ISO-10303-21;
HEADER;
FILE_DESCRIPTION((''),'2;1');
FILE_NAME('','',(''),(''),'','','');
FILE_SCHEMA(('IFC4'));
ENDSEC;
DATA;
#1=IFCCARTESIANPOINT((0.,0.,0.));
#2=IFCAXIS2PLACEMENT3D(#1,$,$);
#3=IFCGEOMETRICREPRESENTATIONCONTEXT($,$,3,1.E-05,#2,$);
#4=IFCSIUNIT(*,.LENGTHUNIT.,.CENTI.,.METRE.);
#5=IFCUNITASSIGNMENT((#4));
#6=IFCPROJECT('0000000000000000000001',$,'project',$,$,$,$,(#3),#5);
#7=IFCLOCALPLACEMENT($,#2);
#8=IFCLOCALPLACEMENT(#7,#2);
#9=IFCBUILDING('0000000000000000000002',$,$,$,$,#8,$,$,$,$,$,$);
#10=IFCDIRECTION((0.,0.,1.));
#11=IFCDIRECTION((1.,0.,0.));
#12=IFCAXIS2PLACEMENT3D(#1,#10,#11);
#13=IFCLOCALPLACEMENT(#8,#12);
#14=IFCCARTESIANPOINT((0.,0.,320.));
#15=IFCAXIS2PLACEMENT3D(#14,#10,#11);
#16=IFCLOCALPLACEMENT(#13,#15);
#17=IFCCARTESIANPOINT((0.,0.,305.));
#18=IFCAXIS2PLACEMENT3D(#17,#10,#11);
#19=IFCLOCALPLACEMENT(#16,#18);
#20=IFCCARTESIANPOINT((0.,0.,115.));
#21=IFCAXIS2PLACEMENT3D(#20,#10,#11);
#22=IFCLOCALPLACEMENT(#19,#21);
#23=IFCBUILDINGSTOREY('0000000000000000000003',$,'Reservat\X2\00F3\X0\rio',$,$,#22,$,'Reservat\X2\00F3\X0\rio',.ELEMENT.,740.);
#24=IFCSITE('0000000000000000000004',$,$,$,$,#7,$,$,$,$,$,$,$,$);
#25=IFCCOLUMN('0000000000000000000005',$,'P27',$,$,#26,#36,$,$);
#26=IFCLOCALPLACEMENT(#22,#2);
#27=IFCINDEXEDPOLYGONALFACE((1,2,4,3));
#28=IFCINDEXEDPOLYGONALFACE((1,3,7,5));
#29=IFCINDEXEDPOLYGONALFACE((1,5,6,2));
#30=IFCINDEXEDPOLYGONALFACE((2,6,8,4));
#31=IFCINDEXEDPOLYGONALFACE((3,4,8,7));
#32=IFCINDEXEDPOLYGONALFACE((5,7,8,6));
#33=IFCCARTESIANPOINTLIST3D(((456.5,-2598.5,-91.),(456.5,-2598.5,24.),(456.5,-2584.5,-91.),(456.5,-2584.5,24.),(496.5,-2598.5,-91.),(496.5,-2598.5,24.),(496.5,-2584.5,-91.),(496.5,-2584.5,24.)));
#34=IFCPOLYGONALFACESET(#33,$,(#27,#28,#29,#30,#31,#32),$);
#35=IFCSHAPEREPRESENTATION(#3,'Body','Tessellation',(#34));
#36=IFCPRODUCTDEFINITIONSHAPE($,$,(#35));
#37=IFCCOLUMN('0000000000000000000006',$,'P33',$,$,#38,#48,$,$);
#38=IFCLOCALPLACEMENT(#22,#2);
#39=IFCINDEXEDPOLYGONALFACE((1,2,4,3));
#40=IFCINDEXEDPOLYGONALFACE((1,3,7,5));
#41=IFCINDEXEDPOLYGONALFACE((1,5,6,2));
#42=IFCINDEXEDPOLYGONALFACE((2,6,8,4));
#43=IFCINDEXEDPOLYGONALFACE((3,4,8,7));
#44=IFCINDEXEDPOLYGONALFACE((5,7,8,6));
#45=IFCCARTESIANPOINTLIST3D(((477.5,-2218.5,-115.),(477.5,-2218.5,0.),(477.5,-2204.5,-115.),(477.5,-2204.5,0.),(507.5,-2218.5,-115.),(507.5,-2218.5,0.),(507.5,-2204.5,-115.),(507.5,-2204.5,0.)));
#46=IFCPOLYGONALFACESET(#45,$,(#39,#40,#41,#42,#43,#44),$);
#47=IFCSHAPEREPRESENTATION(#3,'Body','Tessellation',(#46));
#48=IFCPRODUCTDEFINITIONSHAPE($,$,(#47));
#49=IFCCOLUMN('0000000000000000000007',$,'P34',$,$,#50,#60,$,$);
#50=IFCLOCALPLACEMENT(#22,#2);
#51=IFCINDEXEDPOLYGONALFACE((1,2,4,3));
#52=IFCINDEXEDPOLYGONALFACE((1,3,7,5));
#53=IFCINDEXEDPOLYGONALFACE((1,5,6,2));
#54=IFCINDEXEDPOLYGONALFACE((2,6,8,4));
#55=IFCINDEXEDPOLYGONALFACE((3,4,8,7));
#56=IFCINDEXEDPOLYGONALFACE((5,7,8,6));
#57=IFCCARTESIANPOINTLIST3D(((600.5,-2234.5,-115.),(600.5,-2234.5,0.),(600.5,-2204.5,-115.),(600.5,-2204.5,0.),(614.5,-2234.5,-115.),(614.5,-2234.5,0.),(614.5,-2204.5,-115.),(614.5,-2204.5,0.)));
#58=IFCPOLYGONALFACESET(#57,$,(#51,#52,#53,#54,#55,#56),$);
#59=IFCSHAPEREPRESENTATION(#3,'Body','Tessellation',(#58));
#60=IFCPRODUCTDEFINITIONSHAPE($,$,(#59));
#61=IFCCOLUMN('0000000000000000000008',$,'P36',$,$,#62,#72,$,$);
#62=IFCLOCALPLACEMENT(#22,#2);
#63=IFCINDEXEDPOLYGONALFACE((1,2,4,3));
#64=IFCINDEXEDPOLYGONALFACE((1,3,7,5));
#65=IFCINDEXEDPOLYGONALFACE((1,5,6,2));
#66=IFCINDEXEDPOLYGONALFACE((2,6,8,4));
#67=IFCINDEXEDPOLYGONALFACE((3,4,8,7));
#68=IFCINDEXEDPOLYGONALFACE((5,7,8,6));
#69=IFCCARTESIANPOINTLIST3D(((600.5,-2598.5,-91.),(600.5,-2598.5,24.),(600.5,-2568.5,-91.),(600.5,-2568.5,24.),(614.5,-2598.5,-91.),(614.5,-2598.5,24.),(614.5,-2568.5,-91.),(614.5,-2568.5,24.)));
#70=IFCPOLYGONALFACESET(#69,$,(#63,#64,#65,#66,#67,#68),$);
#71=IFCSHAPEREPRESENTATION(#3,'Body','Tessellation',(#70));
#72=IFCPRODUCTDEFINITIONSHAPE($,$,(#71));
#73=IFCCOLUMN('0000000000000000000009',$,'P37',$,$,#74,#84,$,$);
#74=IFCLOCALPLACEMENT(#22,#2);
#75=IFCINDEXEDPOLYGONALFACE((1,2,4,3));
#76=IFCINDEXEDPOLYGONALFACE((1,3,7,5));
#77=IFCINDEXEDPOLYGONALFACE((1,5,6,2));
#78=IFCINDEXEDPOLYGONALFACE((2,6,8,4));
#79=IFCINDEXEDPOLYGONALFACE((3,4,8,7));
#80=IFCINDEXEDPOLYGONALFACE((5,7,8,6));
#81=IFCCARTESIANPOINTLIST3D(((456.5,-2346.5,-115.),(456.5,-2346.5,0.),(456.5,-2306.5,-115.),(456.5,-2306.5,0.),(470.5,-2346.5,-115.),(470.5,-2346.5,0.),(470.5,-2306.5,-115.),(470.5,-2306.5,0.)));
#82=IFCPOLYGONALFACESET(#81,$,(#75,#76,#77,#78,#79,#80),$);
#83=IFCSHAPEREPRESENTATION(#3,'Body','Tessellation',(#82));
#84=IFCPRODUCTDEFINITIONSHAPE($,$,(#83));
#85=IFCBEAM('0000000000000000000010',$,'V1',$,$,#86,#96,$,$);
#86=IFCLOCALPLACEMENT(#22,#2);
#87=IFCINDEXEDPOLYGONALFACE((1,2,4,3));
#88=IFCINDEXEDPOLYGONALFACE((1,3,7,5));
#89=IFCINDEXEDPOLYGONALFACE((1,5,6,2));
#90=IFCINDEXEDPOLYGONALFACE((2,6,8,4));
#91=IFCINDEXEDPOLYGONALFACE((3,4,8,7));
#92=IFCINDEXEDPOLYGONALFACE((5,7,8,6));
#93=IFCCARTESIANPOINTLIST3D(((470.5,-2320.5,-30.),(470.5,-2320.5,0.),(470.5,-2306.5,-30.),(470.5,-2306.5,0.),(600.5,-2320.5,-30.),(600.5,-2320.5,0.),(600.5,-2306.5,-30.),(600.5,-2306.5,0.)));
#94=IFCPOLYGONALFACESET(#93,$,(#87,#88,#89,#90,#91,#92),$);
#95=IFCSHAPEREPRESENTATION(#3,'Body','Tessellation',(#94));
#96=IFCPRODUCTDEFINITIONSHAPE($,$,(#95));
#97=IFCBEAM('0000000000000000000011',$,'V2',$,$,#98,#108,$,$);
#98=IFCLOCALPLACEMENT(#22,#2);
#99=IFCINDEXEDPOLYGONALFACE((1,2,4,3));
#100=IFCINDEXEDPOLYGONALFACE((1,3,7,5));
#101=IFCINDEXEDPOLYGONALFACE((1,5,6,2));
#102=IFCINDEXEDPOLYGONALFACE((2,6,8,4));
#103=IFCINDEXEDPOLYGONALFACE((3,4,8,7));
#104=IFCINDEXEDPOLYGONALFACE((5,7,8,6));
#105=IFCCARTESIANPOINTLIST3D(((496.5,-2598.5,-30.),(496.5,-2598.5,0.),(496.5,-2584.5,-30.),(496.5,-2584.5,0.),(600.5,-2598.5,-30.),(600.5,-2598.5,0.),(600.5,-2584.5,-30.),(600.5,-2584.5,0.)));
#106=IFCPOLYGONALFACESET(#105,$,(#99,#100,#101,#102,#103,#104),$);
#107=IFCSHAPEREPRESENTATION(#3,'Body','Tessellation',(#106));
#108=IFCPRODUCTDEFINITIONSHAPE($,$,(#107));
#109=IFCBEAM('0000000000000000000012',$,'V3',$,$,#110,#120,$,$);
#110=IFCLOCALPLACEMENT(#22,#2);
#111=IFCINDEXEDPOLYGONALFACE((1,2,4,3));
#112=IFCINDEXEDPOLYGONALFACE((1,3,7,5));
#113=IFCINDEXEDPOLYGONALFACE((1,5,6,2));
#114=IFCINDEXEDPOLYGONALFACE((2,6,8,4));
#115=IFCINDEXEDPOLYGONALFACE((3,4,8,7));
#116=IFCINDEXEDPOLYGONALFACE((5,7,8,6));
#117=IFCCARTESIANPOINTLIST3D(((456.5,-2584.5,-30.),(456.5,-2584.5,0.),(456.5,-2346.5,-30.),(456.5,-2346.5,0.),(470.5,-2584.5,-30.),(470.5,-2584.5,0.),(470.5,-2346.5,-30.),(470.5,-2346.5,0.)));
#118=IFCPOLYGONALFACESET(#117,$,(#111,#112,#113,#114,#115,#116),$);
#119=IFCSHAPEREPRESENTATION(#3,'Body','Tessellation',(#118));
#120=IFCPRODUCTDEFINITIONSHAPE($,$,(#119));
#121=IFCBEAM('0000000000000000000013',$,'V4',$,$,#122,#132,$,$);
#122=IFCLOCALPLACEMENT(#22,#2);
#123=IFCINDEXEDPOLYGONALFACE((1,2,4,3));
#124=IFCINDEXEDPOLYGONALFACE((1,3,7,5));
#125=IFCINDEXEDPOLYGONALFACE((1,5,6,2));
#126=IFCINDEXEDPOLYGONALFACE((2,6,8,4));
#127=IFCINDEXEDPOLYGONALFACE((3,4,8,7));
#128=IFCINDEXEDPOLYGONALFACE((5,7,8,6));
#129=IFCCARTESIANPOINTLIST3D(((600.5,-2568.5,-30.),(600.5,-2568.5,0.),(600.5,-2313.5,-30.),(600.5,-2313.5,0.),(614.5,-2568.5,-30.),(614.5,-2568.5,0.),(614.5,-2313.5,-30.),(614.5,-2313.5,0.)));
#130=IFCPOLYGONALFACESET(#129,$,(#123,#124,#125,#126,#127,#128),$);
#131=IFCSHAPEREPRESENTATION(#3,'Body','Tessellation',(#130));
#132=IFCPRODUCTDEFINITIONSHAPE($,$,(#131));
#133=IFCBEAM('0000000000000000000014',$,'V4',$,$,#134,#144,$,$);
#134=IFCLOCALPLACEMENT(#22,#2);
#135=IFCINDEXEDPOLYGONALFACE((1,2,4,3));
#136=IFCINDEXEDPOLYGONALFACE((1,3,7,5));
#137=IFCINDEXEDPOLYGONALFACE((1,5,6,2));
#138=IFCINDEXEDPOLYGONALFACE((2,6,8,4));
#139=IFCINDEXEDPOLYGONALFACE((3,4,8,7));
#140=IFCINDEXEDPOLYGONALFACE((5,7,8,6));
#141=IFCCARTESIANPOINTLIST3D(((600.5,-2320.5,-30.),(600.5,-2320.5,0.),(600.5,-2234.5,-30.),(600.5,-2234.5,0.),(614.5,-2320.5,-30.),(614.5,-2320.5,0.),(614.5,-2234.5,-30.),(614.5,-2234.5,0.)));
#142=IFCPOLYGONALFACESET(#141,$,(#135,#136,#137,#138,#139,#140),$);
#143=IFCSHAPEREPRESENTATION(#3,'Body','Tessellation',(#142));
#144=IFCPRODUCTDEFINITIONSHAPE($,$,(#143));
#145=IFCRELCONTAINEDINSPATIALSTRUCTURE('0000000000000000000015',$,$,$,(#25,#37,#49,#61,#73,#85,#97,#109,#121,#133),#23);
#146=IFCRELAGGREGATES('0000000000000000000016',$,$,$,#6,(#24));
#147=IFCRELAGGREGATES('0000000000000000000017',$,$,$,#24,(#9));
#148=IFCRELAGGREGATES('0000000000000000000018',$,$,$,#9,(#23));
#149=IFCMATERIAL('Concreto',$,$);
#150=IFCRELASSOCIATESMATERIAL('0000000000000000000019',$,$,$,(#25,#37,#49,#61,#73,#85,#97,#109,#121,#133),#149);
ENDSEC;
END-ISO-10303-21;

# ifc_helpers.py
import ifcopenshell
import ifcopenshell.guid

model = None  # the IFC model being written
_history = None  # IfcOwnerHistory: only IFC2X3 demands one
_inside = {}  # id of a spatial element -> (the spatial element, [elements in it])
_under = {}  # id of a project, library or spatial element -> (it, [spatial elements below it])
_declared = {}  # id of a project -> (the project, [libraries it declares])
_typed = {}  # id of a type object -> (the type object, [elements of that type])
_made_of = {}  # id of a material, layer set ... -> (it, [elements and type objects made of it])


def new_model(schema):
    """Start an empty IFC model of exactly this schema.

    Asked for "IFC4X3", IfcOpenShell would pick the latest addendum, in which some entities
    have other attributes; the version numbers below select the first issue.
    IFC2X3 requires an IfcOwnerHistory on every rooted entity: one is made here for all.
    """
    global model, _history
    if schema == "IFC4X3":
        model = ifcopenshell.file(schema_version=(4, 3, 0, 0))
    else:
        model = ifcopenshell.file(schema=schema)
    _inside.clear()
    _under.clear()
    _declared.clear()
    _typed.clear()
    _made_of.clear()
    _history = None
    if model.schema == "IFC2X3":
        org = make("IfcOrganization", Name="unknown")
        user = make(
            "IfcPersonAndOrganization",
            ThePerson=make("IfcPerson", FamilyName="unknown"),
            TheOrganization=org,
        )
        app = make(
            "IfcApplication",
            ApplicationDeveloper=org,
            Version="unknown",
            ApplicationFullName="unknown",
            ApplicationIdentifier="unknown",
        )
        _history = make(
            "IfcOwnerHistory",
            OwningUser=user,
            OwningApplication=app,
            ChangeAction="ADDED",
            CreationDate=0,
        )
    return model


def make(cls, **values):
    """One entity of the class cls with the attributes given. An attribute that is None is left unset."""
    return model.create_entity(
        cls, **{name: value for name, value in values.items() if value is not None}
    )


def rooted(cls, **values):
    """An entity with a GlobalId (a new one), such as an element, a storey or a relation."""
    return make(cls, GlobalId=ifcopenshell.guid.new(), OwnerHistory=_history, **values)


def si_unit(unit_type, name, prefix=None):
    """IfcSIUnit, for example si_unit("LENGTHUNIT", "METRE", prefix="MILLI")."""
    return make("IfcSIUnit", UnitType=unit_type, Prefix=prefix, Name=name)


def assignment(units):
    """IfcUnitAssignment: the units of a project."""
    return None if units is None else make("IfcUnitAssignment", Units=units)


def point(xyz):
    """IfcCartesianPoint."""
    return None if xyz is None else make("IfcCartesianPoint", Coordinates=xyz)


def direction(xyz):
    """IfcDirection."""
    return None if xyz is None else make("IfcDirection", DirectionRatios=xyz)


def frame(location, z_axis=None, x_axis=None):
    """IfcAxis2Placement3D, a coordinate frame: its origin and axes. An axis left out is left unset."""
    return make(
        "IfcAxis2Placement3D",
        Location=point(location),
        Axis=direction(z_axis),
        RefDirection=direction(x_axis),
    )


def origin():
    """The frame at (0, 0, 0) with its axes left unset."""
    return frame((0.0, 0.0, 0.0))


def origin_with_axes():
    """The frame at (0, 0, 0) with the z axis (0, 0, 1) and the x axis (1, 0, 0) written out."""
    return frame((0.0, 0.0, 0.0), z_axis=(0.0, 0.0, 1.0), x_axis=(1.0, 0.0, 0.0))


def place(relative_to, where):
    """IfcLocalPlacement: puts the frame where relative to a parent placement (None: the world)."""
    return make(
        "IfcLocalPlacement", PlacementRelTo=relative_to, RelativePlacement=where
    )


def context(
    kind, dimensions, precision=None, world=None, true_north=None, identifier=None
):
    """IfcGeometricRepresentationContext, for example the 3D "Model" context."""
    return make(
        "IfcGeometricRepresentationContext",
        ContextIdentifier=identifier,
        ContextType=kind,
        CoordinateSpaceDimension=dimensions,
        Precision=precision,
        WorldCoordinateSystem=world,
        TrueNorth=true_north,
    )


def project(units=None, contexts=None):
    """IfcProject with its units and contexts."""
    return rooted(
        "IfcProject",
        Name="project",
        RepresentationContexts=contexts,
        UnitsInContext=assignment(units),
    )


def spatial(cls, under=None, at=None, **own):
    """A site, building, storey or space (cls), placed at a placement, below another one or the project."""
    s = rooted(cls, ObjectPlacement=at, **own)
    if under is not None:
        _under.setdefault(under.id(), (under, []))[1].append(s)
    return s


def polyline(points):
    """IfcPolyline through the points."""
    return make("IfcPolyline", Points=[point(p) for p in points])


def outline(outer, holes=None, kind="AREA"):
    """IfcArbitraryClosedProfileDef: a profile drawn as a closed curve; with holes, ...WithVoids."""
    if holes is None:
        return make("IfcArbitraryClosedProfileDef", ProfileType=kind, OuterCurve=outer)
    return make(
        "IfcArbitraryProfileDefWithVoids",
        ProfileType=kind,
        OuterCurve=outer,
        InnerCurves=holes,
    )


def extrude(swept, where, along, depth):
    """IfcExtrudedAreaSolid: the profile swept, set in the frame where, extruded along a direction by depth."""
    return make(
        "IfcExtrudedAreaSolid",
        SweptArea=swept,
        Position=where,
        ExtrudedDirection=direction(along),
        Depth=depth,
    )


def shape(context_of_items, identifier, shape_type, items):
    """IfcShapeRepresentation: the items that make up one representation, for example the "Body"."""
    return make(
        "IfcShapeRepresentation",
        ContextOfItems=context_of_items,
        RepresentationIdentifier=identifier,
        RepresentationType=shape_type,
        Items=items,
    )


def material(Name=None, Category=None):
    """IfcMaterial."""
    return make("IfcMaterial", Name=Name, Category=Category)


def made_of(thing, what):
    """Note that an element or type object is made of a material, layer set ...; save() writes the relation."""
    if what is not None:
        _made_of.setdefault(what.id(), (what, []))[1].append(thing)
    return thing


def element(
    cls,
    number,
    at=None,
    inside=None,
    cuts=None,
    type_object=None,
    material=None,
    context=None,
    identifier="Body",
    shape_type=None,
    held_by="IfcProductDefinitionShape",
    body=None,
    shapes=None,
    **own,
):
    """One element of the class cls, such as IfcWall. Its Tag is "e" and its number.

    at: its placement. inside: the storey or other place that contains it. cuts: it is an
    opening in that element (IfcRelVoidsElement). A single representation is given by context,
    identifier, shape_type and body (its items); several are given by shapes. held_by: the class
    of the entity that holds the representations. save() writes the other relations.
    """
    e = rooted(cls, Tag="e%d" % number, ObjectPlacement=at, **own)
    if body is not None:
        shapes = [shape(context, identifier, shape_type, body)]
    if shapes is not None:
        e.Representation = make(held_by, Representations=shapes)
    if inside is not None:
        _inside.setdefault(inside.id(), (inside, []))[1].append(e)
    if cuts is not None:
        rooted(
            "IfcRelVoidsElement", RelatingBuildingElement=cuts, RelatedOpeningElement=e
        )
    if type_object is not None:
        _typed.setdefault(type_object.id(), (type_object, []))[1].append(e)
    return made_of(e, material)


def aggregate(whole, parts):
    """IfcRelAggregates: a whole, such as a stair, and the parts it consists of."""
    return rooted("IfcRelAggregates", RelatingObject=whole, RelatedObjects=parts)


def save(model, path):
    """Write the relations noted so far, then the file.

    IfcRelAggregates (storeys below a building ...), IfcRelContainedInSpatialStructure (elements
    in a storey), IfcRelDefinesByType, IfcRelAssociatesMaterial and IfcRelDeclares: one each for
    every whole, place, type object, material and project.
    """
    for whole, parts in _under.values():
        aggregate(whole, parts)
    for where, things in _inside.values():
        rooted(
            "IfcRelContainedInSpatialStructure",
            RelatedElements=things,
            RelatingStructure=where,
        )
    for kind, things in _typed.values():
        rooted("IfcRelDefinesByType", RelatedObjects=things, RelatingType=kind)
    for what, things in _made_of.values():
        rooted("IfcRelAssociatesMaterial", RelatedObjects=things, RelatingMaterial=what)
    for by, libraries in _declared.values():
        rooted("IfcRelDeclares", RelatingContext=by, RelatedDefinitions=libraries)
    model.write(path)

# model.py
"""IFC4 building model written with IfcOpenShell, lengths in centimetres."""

from ifc_helpers import new_model, si_unit, frame, origin, origin_with_axes, place, context, project, spatial, polyline, outline, extrude, material, element, save


model = new_model("IFC4")

# Units and contexts
context_of_model = context(None, 3, precision=1e-05, world=origin())
ifc_project = project(units=[si_unit("LENGTHUNIT", "METRE", prefix="CENTI")], contexts=[context_of_model])

# Site, building, storey
site_placement = place(None, origin())
site = spatial("IfcSite", under=ifc_project, at=site_placement)
building_placement = place(site_placement, origin())
building = spatial("IfcBuilding", under=site, at=building_placement)
placement_1 = place(building_placement, origin_with_axes())
placement_2 = place(placement_1, frame((0.0, 0.0, 320.0), z_axis=(0.0, 0.0, 1.0), x_axis=(1.0, 0.0, 0.0)))
placement_3 = place(placement_2, frame((0.0, 0.0, 305.0), z_axis=(0.0, 0.0, 1.0), x_axis=(1.0, 0.0, 0.0)))
storey_placement = place(placement_3, frame((0.0, 0.0, 115.0), z_axis=(0.0, 0.0, 1.0), x_axis=(1.0, 0.0, 0.0)))
storey = spatial("IfcBuildingStorey", under=building, at=storey_placement, Name="Reservatório", LongName="Reservatório", CompositionType="ELEMENT", Elevation=740.0)

# Columns
ifc_material = material(Name="Concreto")
column_1_placement = place(storey_placement, frame((476.5, -2591.5, 24.0), z_axis=(0.0, 0.0, 1.0), x_axis=(1.0, 0.0, 0.0)))
element("IfcColumn", 1, at=column_1_placement, inside=storey, material=ifc_material, Name="P27", context=context_of_model, shape_type="SolidModel", body=[
    extrude(outline(polyline([(20.0, -7.0), (20.0, 7.0), (-20.0, 7.0), (-20.0, -7.0), (20.0, -7.0)])), origin_with_axes(), (0.0, 0.0, -1.0), 115.0),
])
column_2_placement = place(storey_placement, frame((492.5, -2211.5, 0.0), z_axis=(0.0, 0.0, 1.0), x_axis=(1.0, 0.0, 0.0)))
element("IfcColumn", 2, at=column_2_placement, inside=storey, material=ifc_material, Name="P33", context=context_of_model, shape_type="SolidModel", body=[
    extrude(outline(polyline([(15.0, -7.0), (15.0, 7.0), (-15.0, 7.0), (-15.0, -7.0), (15.0, -7.0)])), origin_with_axes(), (0.0, 0.0, -1.0), 115.0),
])
for number, where, z_axis, x_axis, name in (
    (3, (607.5, -2219.5, 0.0), (0.0, 0.0, 1.0), (1.0, 0.0, 0.0), "P34"),
    (4, (607.5, -2583.5, 24.0), (0.0, 0.0, 1.0), (1.0, 0.0, 0.0), "P36"),
):
    element("IfcColumn", number, at=place(storey_placement, frame(where, z_axis=z_axis, x_axis=x_axis)), inside=storey, material=ifc_material, Name=name, context=context_of_model, shape_type="SolidModel", body=[
        extrude(outline(polyline([(7.0, 15.0), (-7.0, 15.0), (-7.0, -15.0), (7.0, -15.0), (7.0, 15.0)])), origin_with_axes(), (0.0, 0.0, -1.0), 115.0),
    ])
column_3_placement = place(storey_placement, frame((463.5, -2326.5, 0.0), z_axis=(0.0, 0.0, 1.0), x_axis=(1.0, 0.0, 0.0)))
element("IfcColumn", 5, at=column_3_placement, inside=storey, material=ifc_material, Name="P37", context=context_of_model, shape_type="SolidModel", body=[
    extrude(outline(polyline([(-7.0, -20.0), (7.0, -20.0), (7.0, 20.0), (-7.0, 20.0), (-7.0, -20.0)])), origin_with_axes(), (0.0, 0.0, -1.0), 115.0),
])

# Beams
beam_1_placement = place(storey_placement, frame((535.5, -2313.5, 0.0), z_axis=(0.0, 0.0, 1.0), x_axis=(1.0, 0.0, 0.0)))
element("IfcBeam", 6, at=beam_1_placement, inside=storey, material=ifc_material, Name="V1", context=context_of_model, shape_type="SolidModel", body=[
    extrude(outline(polyline([(-7.0, -15.0), (7.0, -15.0), (7.0, 15.0), (-7.0, 15.0), (-7.0, -15.0)])), frame((-65.0, 0.0, -15.0), z_axis=(1.0, 0.0, 0.0), x_axis=(0.0, -1.0, 0.0)), (0.0, 0.0, 1.0), 130.0),
])
beam_2_placement = place(storey_placement, frame((548.5, -2591.5, 0.0), z_axis=(0.0, 0.0, 1.0), x_axis=(1.0, 0.0, 0.0)))
element("IfcBeam", 7, at=beam_2_placement, inside=storey, material=ifc_material, Name="V2", context=context_of_model, shape_type="SolidModel", body=[
    extrude(outline(polyline([(-7.0, -15.0), (7.0, -15.0), (7.0, 15.0), (-7.0, 15.0), (-7.0, -15.0)])), frame((-52.0, 0.0, -15.0), z_axis=(1.0, 0.0, 0.0), x_axis=(0.0, -1.0, 0.0)), (0.0, 0.0, 1.0), 104.0),
])
beam_3_placement = place(storey_placement, frame((463.5, -2465.5, 0.0), z_axis=(0.0, 0.0, 1.0), x_axis=(1.0, 0.0, 0.0)))
element("IfcBeam", 8, at=beam_3_placement, inside=storey, material=ifc_material, Name="V3", context=context_of_model, shape_type="SolidModel", body=[
    extrude(outline(polyline([(-7.0, -15.0), (7.0, -15.0), (7.0, 15.0), (-7.0, 15.0), (-7.0, -15.0)])), frame((0.0, -119.0, -15.0), z_axis=(0.0, 1.0, 0.0), x_axis=(1.0, 0.0, 0.0)), (0.0, 0.0, 1.0), 238.0),
])
beam_4_placement = place(storey_placement, frame((607.5, -2441.0, 0.0), z_axis=(0.0, 0.0, 1.0), x_axis=(1.0, 0.0, 0.0)))
element("IfcBeam", 9, at=beam_4_placement, inside=storey, material=ifc_material, Name="V4", context=context_of_model, shape_type="SolidModel", body=[
    extrude(outline(polyline([(-7.0, -15.0), (7.0, -15.0), (7.0, 15.0), (-7.0, 15.0), (-7.0, -15.0)])), frame((0.0, -127.5, -15.0), z_axis=(0.0, 1.0, 0.0), x_axis=(1.0, 0.0, 0.0)), (0.0, 0.0, 1.0), 255.0),
])
beam_5_placement = place(storey_placement, frame((607.5, -2277.5, 0.0), z_axis=(0.0, 0.0, 1.0), x_axis=(1.0, 0.0, 0.0)))
element("IfcBeam", 10, at=beam_5_placement, inside=storey, material=ifc_material, Name="V4", context=context_of_model, shape_type="SolidModel", body=[
    extrude(outline(polyline([(-7.0, -15.0), (7.0, -15.0), (7.0, 15.0), (-7.0, 15.0), (-7.0, -15.0)])), frame((0.0, -43.0, -15.0), z_axis=(0.0, 1.0, 0.0), x_axis=(1.0, 0.0, 0.0)), (0.0, 0.0, 1.0), 86.0),
])

save(model, "model.ifc")
